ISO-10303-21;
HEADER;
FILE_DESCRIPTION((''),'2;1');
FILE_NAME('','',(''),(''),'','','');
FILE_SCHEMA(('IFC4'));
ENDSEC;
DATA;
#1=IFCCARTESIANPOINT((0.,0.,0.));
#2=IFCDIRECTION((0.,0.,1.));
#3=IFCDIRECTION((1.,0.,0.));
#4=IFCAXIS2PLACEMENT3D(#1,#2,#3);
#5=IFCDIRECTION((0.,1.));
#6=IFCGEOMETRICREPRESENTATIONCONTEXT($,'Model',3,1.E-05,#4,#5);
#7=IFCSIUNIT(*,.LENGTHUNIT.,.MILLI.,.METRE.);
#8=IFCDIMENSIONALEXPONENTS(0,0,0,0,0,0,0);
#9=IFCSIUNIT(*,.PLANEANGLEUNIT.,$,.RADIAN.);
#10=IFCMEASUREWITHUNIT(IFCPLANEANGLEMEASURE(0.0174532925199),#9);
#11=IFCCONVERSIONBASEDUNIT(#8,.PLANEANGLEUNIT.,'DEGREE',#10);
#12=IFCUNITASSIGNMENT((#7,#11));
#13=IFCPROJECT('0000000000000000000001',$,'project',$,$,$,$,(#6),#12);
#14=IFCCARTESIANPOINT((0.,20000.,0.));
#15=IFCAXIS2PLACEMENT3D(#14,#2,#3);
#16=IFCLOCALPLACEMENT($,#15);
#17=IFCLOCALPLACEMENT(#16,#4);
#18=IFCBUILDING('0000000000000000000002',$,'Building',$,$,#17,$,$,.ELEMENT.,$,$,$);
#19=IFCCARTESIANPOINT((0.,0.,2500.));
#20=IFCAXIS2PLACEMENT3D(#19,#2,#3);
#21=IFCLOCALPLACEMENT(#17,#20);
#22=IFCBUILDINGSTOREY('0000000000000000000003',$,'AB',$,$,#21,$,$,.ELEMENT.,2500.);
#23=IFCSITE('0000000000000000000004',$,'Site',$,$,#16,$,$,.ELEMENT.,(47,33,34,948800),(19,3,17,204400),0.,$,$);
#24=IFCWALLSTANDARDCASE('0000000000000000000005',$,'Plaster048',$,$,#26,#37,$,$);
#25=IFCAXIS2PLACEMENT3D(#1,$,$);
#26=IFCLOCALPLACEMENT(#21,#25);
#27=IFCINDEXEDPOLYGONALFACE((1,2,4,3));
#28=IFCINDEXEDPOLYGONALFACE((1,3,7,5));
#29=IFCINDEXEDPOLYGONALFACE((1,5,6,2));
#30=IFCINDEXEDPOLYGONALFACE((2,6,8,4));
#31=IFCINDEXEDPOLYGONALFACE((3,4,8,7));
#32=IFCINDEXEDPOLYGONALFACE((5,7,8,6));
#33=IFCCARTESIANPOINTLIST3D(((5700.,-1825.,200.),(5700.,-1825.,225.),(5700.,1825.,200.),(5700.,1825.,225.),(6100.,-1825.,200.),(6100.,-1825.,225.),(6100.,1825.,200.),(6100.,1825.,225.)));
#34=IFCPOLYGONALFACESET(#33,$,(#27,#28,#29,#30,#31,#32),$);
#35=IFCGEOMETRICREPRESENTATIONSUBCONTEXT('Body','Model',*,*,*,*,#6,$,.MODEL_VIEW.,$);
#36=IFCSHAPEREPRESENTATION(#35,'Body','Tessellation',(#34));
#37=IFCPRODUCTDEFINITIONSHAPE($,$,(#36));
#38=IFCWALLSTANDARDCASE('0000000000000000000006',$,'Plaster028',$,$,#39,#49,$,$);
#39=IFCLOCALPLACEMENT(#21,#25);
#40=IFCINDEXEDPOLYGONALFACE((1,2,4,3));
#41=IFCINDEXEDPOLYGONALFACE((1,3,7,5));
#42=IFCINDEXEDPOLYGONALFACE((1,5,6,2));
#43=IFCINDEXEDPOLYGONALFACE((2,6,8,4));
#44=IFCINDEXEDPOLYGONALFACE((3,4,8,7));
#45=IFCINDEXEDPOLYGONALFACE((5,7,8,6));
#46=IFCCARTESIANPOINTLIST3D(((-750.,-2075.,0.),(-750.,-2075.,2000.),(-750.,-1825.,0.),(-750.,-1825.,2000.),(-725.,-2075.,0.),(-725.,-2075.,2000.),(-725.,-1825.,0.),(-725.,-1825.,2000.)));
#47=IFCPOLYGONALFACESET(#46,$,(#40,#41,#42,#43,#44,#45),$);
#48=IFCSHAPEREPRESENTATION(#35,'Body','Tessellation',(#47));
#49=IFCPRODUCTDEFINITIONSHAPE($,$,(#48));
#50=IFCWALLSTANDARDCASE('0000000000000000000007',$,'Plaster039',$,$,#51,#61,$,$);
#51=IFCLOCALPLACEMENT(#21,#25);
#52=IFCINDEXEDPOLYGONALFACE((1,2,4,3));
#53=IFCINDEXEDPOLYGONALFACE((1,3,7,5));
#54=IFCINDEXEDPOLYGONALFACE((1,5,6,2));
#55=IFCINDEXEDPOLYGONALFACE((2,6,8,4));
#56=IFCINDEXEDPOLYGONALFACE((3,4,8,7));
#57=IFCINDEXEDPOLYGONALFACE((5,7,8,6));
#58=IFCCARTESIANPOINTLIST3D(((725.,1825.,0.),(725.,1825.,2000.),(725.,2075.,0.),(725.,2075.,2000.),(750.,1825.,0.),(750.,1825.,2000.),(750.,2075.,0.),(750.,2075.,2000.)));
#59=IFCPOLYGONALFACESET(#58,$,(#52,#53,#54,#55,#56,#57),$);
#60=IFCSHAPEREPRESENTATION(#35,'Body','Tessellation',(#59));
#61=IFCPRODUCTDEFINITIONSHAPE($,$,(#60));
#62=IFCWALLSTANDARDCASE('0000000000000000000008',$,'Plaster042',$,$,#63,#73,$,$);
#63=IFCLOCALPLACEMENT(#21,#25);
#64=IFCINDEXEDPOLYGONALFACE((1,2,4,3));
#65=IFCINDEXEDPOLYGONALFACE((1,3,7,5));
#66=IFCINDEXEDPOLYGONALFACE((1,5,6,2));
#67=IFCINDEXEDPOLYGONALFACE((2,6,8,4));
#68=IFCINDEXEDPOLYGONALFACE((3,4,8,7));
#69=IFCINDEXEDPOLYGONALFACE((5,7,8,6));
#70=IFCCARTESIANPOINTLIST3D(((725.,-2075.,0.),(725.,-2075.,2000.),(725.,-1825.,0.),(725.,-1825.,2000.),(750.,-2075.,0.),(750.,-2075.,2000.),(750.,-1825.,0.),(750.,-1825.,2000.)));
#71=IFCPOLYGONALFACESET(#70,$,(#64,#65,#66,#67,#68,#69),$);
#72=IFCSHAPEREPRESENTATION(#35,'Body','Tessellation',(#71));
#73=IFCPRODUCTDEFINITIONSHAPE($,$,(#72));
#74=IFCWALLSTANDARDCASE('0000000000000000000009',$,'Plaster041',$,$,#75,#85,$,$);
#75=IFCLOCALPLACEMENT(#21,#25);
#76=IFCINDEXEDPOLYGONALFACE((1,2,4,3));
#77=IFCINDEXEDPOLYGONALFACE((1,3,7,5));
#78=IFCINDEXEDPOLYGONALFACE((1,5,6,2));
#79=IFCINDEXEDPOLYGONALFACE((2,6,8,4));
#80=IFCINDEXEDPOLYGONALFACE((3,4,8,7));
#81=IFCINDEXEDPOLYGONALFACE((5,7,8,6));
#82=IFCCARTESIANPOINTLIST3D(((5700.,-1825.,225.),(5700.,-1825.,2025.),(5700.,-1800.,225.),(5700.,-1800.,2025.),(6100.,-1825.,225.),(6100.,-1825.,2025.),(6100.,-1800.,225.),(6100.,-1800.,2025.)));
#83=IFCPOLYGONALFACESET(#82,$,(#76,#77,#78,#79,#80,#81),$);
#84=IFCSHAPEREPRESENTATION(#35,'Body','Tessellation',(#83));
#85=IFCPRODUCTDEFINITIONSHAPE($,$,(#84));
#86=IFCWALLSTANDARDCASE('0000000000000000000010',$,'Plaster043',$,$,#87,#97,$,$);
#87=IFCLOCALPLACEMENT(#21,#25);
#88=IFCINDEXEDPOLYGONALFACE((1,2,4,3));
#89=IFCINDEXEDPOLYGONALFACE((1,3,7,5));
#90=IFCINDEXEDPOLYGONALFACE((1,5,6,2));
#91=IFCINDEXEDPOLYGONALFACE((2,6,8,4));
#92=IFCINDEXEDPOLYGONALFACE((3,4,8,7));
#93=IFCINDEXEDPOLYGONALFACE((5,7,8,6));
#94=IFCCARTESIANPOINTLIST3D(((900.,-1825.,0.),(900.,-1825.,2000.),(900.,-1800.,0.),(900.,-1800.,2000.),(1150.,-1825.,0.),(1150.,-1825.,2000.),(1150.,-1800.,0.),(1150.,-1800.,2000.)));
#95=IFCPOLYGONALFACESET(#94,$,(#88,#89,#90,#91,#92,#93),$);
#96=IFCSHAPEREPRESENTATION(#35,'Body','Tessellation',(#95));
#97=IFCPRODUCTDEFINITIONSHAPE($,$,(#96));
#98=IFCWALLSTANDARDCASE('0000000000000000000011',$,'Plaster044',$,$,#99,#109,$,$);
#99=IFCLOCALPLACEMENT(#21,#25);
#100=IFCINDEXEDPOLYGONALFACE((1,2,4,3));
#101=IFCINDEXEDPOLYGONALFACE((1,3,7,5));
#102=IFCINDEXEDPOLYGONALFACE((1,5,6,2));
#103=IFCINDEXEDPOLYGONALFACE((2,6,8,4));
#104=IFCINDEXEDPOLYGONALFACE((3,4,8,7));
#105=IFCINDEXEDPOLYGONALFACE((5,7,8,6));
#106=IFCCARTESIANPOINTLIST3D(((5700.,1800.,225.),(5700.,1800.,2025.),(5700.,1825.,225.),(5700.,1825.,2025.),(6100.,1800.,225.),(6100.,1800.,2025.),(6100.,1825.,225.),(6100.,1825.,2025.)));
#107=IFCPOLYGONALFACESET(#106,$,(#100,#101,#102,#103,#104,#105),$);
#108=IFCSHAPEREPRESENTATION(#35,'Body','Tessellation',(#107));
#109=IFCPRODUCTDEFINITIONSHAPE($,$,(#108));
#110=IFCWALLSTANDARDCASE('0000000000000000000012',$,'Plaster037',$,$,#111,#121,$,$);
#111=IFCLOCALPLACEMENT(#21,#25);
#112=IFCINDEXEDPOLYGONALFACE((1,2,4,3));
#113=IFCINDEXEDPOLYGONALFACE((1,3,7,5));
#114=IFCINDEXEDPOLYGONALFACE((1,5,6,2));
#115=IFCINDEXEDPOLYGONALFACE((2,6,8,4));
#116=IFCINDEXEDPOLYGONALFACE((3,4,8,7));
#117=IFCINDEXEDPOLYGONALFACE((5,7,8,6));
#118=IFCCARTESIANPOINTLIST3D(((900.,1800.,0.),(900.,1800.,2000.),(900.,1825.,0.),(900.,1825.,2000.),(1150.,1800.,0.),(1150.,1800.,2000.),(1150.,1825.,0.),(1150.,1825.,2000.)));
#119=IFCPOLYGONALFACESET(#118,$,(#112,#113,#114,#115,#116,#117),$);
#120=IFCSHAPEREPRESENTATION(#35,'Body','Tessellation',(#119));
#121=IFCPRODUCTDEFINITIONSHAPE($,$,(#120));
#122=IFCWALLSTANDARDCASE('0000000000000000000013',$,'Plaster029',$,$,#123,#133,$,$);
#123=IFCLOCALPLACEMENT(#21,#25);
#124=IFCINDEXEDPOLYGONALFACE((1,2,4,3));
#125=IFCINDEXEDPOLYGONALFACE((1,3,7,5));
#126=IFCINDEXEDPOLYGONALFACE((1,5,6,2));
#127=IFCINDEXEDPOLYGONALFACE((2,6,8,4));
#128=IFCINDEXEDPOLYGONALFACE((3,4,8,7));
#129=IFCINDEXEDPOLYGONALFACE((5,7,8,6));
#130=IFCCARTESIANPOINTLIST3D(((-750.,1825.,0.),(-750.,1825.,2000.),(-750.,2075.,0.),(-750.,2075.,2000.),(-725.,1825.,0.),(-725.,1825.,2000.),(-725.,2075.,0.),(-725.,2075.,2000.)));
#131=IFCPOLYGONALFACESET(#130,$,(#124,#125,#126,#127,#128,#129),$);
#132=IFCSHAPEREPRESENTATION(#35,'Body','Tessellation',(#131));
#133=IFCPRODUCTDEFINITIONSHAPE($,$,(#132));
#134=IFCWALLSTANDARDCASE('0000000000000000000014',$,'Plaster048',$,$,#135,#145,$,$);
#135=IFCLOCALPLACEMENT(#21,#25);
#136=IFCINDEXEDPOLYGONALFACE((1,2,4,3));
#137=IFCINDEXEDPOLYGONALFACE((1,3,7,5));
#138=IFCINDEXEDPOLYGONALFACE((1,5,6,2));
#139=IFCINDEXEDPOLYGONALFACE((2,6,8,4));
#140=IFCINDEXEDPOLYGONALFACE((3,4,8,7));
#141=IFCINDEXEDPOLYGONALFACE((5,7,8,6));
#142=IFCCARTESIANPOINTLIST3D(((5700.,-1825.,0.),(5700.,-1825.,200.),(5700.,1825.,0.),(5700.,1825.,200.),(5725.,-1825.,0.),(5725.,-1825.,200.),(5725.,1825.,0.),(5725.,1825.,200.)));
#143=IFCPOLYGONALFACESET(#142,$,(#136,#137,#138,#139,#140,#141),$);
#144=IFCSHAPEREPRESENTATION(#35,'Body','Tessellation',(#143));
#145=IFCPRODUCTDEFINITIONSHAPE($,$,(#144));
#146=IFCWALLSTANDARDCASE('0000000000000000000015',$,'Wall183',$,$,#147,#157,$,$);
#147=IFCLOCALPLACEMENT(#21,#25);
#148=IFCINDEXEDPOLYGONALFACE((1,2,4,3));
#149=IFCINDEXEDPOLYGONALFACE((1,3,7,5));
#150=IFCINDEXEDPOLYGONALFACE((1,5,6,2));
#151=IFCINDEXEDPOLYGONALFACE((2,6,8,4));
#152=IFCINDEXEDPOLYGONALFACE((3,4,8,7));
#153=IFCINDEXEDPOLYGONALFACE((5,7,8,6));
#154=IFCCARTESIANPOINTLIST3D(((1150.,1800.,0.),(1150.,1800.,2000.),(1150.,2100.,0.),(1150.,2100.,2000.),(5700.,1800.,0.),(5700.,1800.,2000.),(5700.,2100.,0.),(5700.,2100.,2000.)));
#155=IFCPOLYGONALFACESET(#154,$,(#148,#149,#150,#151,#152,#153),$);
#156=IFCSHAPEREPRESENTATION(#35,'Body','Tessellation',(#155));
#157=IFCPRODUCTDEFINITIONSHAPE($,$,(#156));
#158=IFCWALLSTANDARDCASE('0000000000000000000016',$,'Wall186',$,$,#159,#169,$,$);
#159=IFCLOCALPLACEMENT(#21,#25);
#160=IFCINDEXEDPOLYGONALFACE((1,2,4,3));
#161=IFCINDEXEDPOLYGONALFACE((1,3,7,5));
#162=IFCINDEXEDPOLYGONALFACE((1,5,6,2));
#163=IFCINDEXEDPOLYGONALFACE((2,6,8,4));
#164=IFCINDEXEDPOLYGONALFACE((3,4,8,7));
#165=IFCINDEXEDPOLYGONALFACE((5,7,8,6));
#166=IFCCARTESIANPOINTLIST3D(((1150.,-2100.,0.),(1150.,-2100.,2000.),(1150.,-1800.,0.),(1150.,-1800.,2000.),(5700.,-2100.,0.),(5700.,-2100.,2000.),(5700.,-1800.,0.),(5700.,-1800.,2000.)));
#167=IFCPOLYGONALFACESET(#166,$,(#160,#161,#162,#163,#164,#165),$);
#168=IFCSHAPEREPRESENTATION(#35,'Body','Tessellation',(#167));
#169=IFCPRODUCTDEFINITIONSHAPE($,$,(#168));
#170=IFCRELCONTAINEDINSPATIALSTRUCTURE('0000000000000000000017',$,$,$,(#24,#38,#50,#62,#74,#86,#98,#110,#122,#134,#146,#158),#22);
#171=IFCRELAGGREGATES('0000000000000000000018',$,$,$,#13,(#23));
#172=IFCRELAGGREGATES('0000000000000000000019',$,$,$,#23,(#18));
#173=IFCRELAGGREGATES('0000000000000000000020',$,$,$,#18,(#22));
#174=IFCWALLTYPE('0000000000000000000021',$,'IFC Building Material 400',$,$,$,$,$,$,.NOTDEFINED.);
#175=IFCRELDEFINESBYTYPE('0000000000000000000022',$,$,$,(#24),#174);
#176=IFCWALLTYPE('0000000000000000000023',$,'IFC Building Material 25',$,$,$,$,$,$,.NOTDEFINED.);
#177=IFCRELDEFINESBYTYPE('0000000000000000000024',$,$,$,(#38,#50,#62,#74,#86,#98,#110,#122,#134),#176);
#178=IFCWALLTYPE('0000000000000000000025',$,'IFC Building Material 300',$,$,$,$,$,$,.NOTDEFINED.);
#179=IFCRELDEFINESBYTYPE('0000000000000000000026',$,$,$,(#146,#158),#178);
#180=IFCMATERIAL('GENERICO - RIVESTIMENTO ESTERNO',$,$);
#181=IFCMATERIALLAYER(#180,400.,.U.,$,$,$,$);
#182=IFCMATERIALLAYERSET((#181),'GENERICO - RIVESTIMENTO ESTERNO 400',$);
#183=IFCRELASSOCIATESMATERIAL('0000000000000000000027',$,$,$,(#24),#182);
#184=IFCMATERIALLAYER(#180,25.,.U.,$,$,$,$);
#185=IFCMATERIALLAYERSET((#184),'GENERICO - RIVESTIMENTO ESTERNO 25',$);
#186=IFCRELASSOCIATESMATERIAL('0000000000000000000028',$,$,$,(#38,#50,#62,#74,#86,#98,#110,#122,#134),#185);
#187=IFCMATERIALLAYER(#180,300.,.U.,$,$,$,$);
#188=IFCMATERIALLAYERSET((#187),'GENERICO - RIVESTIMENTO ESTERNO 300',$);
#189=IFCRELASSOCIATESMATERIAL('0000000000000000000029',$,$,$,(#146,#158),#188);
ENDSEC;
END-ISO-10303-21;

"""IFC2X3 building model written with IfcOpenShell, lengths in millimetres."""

from ifc_helpers import new_model, entity, si_unit, converted_unit, direction, frame, origin_with_axes, place, context, subcontext, project, spatial, polyline, outline, extrude, material, layer, layer_set, layer_usage, type_object, element, save


model = new_model("IFC2X3")

# Units and contexts
model_context = context("Model", 3, precision=1e-05, world=origin_with_axes(), true_north=direction((0.0, 1.0)))
body_context = subcontext(model_context, "Body", "Model", "MODEL_VIEW")
ifc_project = project(units=[si_unit("LENGTHUNIT", "METRE", prefix="MILLI"), converted_unit("PLANEANGLEUNIT", "DEGREE", entity("IfcPlaneAngleMeasure", 0.0174532925199), si_unit("PLANEANGLEUNIT", "RADIAN"), dimensions=[0, 0, 0, 0, 0, 0, 0])], contexts=[model_context])

# Site, building, storey
site_placement = place(None, frame((0.0, 20000.0, 0.0), z_axis=(0.0, 0.0, 1.0), x_axis=(1.0, 0.0, 0.0)))
site = spatial("IfcSite", under=ifc_project, at=site_placement, Name="Site", CompositionType="ELEMENT", RefLatitude=(47, 33, 34, 948800), RefLongitude=(19, 3, 17, 204400), RefElevation=0.0)
building_placement = place(site_placement, origin_with_axes())
building = spatial("IfcBuilding", under=site, at=building_placement, Name="Building", CompositionType="ELEMENT")
storey_placement = place(building_placement, frame((0.0, 0.0, 2500.0), z_axis=(0.0, 0.0, 1.0), x_axis=(1.0, 0.0, 0.0)))
storey = spatial("IfcBuildingStorey", under=building, at=storey_placement, Name="AB", CompositionType="ELEMENT", Elevation=2500.0)

# Shared definitions
ifc_material_1 = material(Name="GENERICO - RIVESTIMENTO ESTERNO")

# Walls
ifc_layer_1 = layer(ifc_material_1, 400.0, ventilated="UNKNOWN")
ifc_layer_set_1 = layer_set([ifc_layer_1], Name="GENERICO - RIVESTIMENTO ESTERNO 400")
ifc_layer_usage_1 = layer_usage(ifc_layer_set_1, "AXIS2", "POSITIVE", 0.0)
wall_type_1 = type_object("IfcWallType", Name="IFC Building Material 400", PredefinedType="NOTDEFINED")
wall_1_placement = place(storey_placement, frame((6100.0, -1825.0, 200.0), z_axis=(0.0, 0.0, 1.0), x_axis=(0.0, 1.0, 0.0)))
element("IfcWallStandardCase", 1, at=wall_1_placement, inside=storey, type_object=wall_type_1, material=ifc_layer_usage_1, Name="Plaster048", context=body_context, shape_type="SweptSolid", body=[
    extrude(outline(polyline([(0.0, 0.0), (3650.0, 0.0), (3650.0, 400.0), (0.0, 400.0), (0.0, 0.0)])), origin_with_axes(), (0.0, 0.0, 1.0), 25.0),
])
ifc_layer_2 = layer(ifc_material_1, 25.0, ventilated="UNKNOWN")
ifc_layer_set_2 = layer_set([ifc_layer_2], Name="GENERICO - RIVESTIMENTO ESTERNO 25")
ifc_layer_usage_2 = layer_usage(ifc_layer_set_2, "AXIS2", "POSITIVE", -25.0)
wall_type_2 = type_object("IfcWallType", Name="IFC Building Material 25", PredefinedType="NOTDEFINED")
wall_2_placement = place(storey_placement, frame((-725.0, -1825.0, 0.0), z_axis=(0.0, 0.0, 1.0), x_axis=(0.0, -1.0, 0.0)))
element("IfcWallStandardCase", 2, at=wall_2_placement, inside=storey, type_object=wall_type_2, material=ifc_layer_usage_2, Name="Plaster028", context=body_context, shape_type="SweptSolid", body=[
    extrude(outline(polyline([(0.0, -25.0), (250.0, -25.0), (250.0, 0.0), (0.0, 0.0), (0.0, -25.0)])), origin_with_axes(), (0.0, 0.0, 1.0), 2000.0),
])
ifc_layer_usage_3 = layer_usage(ifc_layer_set_2, "AXIS2", "POSITIVE", -25.0)
wall_3_placement = place(storey_placement, frame((725.0, 1825.0, 0.0), z_axis=(0.0, 0.0, 1.0), x_axis=(0.0, 1.0, 0.0)))
element("IfcWallStandardCase", 3, at=wall_3_placement, inside=storey, type_object=wall_type_2, material=ifc_layer_usage_3, Name="Plaster039", context=body_context, shape_type="SweptSolid", body=[
    extrude(outline(polyline([(0.0, -25.0), (250.0, -25.0), (250.0, 0.0), (0.0, 0.0), (0.0, -25.0)])), origin_with_axes(), (0.0, 0.0, 1.0), 2000.0),
])
ifc_layer_usage_4 = layer_usage(ifc_layer_set_2, "AXIS2", "POSITIVE", 0.0)
wall_4_placement = place(storey_placement, frame((725.0, -1825.0, 0.0), z_axis=(0.0, 0.0, 1.0), x_axis=(0.0, -1.0, 0.0)))
element("IfcWallStandardCase", 4, at=wall_4_placement, inside=storey, type_object=wall_type_2, material=ifc_layer_usage_4, Name="Plaster042", context=body_context, shape_type="SweptSolid", body=[
    extrude(outline(polyline([(0.0, 0.0), (250.0, 0.0), (250.0, 25.0), (0.0, 25.0), (0.0, 0.0)])), origin_with_axes(), (0.0, 0.0, 1.0), 2000.0),
])
ifc_layer_usage_5 = layer_usage(ifc_layer_set_2, "AXIS2", "POSITIVE", 0.0)
wall_5_placement = place(storey_placement, frame((6100.0, -1800.0, 225.0), z_axis=(0.0, 0.0, 1.0), x_axis=(-1.0, 0.0, 0.0)))
element("IfcWallStandardCase", 5, at=wall_5_placement, inside=storey, type_object=wall_type_2, material=ifc_layer_usage_5, Name="Plaster041", context=body_context, shape_type="SweptSolid", body=[
    extrude(outline(polyline([(0.0, 0.0), (400.0, 0.0), (400.0, 25.0), (0.0, 25.0), (0.0, 0.0)])), origin_with_axes(), (0.0, 0.0, 1.0), 1800.0),
])
ifc_layer_usage_6 = layer_usage(ifc_layer_set_2, "AXIS2", "POSITIVE", 0.0)
wall_6_placement = place(storey_placement, frame((1150.0, -1800.0, 0.0), z_axis=(0.0, 0.0, 1.0), x_axis=(-1.0, 0.0, 0.0)))
element("IfcWallStandardCase", 6, at=wall_6_placement, inside=storey, type_object=wall_type_2, material=ifc_layer_usage_6, Name="Plaster043", context=body_context, shape_type="SweptSolid", body=[
    extrude(outline(polyline([(0.0, 0.0), (250.0, 0.0), (250.0, 25.0), (0.0, 25.0), (0.0, 0.0)])), origin_with_axes(), (0.0, 0.0, 1.0), 2000.0),
])
ifc_layer_usage_7 = layer_usage(ifc_layer_set_2, "AXIS2", "POSITIVE", -25.0)
wall_7_placement = place(storey_placement, frame((6100.0, 1800.0, 225.0), z_axis=(0.0, 0.0, 1.0), x_axis=(-1.0, 0.0, 0.0)))
element("IfcWallStandardCase", 7, at=wall_7_placement, inside=storey, type_object=wall_type_2, material=ifc_layer_usage_7, Name="Plaster044", context=body_context, shape_type="SweptSolid", body=[
    extrude(outline(polyline([(0.0, -25.0), (400.0, -25.0), (400.0, 0.0), (0.0, 0.0), (0.0, -25.0)])), origin_with_axes(), (0.0, 0.0, 1.0), 1800.0),
])
ifc_layer_usage_8 = layer_usage(ifc_layer_set_2, "AXIS2", "POSITIVE", -25.0)
wall_8_placement = place(storey_placement, frame((1150.0, 1800.0, 0.0), z_axis=(0.0, 0.0, 1.0), x_axis=(-1.0, 0.0, 0.0)))
element("IfcWallStandardCase", 8, at=wall_8_placement, inside=storey, type_object=wall_type_2, material=ifc_layer_usage_8, Name="Plaster037", context=body_context, shape_type="SweptSolid", body=[
    extrude(outline(polyline([(0.0, -25.0), (250.0, -25.0), (250.0, 0.0), (0.0, 0.0), (0.0, -25.0)])), origin_with_axes(), (0.0, 0.0, 1.0), 2000.0),
])
ifc_layer_usage_9 = layer_usage(ifc_layer_set_2, "AXIS2", "POSITIVE", 0.0)
wall_9_placement = place(storey_placement, frame((-725.0, 1825.0, 0.0), z_axis=(0.0, 0.0, 1.0), x_axis=(0.0, 1.0, 0.0)))
element("IfcWallStandardCase", 9, at=wall_9_placement, inside=storey, type_object=wall_type_2, material=ifc_layer_usage_9, Name="Plaster029", context=body_context, shape_type="SweptSolid", body=[
    extrude(outline(polyline([(0.0, 0.0), (250.0, 0.0), (250.0, 25.0), (0.0, 25.0), (0.0, 0.0)])), origin_with_axes(), (0.0, 0.0, 1.0), 2000.0),
])
ifc_layer_usage_10 = layer_usage(ifc_layer_set_2, "AXIS2", "POSITIVE", 0.0)
wall_10_placement = place(storey_placement, frame((5725.0, -1825.0, 0.0), z_axis=(0.0, 0.0, 1.0), x_axis=(0.0, 1.0, 0.0)))
element("IfcWallStandardCase", 10, at=wall_10_placement, inside=storey, type_object=wall_type_2, material=ifc_layer_usage_10, Name="Plaster048", context=body_context, shape_type="SweptSolid", body=[
    extrude(outline(polyline([(0.0, 0.0), (3650.0, 0.0), (3650.0, 25.0), (0.0, 25.0), (0.0, 0.0)])), origin_with_axes(), (0.0, 0.0, 1.0), 200.0),
])
ifc_layer_3 = layer(ifc_material_1, 300.0, ventilated="UNKNOWN")
ifc_layer_set_3 = layer_set([ifc_layer_3], Name="GENERICO - RIVESTIMENTO ESTERNO 300")
ifc_layer_usage_11 = layer_usage(ifc_layer_set_3, "AXIS2", "POSITIVE", 0.0)
wall_type_3 = type_object("IfcWallType", Name="IFC Building Material 300", PredefinedType="NOTDEFINED")
wall_11_placement = place(storey_placement, frame((1150.0, 1800.0, 0.0), z_axis=(0.0, 0.0, 1.0), x_axis=(1.0, 0.0, 0.0)))
element("IfcWallStandardCase", 11, at=wall_11_placement, inside=storey, type_object=wall_type_3, material=ifc_layer_usage_11, Name="Wall183", context=body_context, shape_type="SweptSolid", body=[
    extrude(outline(polyline([(0.0, 0.0), (4550.0, 0.0), (4550.0, 300.0), (0.0, 300.0), (0.0, 0.0)])), origin_with_axes(), (0.0, 0.0, 1.0), 2000.0),
])
ifc_layer_usage_12 = layer_usage(ifc_layer_set_3, "AXIS2", "POSITIVE", -300.0)
wall_12_placement = place(storey_placement, frame((1150.0, -1800.0, 0.0), z_axis=(0.0, 0.0, 1.0), x_axis=(1.0, 0.0, 0.0)))
element("IfcWallStandardCase", 12, at=wall_12_placement, inside=storey, type_object=wall_type_3, material=ifc_layer_usage_12, Name="Wall186", context=body_context, shape_type="SweptSolid", body=[
    extrude(outline(polyline([(0.0, -300.0), (4550.0, -300.0), (4550.0, 0.0), (0.0, 0.0), (0.0, -300.0)])), origin_with_axes(), (0.0, 0.0, 1.0), 2000.0),
])

save(model, "model.ifc")
